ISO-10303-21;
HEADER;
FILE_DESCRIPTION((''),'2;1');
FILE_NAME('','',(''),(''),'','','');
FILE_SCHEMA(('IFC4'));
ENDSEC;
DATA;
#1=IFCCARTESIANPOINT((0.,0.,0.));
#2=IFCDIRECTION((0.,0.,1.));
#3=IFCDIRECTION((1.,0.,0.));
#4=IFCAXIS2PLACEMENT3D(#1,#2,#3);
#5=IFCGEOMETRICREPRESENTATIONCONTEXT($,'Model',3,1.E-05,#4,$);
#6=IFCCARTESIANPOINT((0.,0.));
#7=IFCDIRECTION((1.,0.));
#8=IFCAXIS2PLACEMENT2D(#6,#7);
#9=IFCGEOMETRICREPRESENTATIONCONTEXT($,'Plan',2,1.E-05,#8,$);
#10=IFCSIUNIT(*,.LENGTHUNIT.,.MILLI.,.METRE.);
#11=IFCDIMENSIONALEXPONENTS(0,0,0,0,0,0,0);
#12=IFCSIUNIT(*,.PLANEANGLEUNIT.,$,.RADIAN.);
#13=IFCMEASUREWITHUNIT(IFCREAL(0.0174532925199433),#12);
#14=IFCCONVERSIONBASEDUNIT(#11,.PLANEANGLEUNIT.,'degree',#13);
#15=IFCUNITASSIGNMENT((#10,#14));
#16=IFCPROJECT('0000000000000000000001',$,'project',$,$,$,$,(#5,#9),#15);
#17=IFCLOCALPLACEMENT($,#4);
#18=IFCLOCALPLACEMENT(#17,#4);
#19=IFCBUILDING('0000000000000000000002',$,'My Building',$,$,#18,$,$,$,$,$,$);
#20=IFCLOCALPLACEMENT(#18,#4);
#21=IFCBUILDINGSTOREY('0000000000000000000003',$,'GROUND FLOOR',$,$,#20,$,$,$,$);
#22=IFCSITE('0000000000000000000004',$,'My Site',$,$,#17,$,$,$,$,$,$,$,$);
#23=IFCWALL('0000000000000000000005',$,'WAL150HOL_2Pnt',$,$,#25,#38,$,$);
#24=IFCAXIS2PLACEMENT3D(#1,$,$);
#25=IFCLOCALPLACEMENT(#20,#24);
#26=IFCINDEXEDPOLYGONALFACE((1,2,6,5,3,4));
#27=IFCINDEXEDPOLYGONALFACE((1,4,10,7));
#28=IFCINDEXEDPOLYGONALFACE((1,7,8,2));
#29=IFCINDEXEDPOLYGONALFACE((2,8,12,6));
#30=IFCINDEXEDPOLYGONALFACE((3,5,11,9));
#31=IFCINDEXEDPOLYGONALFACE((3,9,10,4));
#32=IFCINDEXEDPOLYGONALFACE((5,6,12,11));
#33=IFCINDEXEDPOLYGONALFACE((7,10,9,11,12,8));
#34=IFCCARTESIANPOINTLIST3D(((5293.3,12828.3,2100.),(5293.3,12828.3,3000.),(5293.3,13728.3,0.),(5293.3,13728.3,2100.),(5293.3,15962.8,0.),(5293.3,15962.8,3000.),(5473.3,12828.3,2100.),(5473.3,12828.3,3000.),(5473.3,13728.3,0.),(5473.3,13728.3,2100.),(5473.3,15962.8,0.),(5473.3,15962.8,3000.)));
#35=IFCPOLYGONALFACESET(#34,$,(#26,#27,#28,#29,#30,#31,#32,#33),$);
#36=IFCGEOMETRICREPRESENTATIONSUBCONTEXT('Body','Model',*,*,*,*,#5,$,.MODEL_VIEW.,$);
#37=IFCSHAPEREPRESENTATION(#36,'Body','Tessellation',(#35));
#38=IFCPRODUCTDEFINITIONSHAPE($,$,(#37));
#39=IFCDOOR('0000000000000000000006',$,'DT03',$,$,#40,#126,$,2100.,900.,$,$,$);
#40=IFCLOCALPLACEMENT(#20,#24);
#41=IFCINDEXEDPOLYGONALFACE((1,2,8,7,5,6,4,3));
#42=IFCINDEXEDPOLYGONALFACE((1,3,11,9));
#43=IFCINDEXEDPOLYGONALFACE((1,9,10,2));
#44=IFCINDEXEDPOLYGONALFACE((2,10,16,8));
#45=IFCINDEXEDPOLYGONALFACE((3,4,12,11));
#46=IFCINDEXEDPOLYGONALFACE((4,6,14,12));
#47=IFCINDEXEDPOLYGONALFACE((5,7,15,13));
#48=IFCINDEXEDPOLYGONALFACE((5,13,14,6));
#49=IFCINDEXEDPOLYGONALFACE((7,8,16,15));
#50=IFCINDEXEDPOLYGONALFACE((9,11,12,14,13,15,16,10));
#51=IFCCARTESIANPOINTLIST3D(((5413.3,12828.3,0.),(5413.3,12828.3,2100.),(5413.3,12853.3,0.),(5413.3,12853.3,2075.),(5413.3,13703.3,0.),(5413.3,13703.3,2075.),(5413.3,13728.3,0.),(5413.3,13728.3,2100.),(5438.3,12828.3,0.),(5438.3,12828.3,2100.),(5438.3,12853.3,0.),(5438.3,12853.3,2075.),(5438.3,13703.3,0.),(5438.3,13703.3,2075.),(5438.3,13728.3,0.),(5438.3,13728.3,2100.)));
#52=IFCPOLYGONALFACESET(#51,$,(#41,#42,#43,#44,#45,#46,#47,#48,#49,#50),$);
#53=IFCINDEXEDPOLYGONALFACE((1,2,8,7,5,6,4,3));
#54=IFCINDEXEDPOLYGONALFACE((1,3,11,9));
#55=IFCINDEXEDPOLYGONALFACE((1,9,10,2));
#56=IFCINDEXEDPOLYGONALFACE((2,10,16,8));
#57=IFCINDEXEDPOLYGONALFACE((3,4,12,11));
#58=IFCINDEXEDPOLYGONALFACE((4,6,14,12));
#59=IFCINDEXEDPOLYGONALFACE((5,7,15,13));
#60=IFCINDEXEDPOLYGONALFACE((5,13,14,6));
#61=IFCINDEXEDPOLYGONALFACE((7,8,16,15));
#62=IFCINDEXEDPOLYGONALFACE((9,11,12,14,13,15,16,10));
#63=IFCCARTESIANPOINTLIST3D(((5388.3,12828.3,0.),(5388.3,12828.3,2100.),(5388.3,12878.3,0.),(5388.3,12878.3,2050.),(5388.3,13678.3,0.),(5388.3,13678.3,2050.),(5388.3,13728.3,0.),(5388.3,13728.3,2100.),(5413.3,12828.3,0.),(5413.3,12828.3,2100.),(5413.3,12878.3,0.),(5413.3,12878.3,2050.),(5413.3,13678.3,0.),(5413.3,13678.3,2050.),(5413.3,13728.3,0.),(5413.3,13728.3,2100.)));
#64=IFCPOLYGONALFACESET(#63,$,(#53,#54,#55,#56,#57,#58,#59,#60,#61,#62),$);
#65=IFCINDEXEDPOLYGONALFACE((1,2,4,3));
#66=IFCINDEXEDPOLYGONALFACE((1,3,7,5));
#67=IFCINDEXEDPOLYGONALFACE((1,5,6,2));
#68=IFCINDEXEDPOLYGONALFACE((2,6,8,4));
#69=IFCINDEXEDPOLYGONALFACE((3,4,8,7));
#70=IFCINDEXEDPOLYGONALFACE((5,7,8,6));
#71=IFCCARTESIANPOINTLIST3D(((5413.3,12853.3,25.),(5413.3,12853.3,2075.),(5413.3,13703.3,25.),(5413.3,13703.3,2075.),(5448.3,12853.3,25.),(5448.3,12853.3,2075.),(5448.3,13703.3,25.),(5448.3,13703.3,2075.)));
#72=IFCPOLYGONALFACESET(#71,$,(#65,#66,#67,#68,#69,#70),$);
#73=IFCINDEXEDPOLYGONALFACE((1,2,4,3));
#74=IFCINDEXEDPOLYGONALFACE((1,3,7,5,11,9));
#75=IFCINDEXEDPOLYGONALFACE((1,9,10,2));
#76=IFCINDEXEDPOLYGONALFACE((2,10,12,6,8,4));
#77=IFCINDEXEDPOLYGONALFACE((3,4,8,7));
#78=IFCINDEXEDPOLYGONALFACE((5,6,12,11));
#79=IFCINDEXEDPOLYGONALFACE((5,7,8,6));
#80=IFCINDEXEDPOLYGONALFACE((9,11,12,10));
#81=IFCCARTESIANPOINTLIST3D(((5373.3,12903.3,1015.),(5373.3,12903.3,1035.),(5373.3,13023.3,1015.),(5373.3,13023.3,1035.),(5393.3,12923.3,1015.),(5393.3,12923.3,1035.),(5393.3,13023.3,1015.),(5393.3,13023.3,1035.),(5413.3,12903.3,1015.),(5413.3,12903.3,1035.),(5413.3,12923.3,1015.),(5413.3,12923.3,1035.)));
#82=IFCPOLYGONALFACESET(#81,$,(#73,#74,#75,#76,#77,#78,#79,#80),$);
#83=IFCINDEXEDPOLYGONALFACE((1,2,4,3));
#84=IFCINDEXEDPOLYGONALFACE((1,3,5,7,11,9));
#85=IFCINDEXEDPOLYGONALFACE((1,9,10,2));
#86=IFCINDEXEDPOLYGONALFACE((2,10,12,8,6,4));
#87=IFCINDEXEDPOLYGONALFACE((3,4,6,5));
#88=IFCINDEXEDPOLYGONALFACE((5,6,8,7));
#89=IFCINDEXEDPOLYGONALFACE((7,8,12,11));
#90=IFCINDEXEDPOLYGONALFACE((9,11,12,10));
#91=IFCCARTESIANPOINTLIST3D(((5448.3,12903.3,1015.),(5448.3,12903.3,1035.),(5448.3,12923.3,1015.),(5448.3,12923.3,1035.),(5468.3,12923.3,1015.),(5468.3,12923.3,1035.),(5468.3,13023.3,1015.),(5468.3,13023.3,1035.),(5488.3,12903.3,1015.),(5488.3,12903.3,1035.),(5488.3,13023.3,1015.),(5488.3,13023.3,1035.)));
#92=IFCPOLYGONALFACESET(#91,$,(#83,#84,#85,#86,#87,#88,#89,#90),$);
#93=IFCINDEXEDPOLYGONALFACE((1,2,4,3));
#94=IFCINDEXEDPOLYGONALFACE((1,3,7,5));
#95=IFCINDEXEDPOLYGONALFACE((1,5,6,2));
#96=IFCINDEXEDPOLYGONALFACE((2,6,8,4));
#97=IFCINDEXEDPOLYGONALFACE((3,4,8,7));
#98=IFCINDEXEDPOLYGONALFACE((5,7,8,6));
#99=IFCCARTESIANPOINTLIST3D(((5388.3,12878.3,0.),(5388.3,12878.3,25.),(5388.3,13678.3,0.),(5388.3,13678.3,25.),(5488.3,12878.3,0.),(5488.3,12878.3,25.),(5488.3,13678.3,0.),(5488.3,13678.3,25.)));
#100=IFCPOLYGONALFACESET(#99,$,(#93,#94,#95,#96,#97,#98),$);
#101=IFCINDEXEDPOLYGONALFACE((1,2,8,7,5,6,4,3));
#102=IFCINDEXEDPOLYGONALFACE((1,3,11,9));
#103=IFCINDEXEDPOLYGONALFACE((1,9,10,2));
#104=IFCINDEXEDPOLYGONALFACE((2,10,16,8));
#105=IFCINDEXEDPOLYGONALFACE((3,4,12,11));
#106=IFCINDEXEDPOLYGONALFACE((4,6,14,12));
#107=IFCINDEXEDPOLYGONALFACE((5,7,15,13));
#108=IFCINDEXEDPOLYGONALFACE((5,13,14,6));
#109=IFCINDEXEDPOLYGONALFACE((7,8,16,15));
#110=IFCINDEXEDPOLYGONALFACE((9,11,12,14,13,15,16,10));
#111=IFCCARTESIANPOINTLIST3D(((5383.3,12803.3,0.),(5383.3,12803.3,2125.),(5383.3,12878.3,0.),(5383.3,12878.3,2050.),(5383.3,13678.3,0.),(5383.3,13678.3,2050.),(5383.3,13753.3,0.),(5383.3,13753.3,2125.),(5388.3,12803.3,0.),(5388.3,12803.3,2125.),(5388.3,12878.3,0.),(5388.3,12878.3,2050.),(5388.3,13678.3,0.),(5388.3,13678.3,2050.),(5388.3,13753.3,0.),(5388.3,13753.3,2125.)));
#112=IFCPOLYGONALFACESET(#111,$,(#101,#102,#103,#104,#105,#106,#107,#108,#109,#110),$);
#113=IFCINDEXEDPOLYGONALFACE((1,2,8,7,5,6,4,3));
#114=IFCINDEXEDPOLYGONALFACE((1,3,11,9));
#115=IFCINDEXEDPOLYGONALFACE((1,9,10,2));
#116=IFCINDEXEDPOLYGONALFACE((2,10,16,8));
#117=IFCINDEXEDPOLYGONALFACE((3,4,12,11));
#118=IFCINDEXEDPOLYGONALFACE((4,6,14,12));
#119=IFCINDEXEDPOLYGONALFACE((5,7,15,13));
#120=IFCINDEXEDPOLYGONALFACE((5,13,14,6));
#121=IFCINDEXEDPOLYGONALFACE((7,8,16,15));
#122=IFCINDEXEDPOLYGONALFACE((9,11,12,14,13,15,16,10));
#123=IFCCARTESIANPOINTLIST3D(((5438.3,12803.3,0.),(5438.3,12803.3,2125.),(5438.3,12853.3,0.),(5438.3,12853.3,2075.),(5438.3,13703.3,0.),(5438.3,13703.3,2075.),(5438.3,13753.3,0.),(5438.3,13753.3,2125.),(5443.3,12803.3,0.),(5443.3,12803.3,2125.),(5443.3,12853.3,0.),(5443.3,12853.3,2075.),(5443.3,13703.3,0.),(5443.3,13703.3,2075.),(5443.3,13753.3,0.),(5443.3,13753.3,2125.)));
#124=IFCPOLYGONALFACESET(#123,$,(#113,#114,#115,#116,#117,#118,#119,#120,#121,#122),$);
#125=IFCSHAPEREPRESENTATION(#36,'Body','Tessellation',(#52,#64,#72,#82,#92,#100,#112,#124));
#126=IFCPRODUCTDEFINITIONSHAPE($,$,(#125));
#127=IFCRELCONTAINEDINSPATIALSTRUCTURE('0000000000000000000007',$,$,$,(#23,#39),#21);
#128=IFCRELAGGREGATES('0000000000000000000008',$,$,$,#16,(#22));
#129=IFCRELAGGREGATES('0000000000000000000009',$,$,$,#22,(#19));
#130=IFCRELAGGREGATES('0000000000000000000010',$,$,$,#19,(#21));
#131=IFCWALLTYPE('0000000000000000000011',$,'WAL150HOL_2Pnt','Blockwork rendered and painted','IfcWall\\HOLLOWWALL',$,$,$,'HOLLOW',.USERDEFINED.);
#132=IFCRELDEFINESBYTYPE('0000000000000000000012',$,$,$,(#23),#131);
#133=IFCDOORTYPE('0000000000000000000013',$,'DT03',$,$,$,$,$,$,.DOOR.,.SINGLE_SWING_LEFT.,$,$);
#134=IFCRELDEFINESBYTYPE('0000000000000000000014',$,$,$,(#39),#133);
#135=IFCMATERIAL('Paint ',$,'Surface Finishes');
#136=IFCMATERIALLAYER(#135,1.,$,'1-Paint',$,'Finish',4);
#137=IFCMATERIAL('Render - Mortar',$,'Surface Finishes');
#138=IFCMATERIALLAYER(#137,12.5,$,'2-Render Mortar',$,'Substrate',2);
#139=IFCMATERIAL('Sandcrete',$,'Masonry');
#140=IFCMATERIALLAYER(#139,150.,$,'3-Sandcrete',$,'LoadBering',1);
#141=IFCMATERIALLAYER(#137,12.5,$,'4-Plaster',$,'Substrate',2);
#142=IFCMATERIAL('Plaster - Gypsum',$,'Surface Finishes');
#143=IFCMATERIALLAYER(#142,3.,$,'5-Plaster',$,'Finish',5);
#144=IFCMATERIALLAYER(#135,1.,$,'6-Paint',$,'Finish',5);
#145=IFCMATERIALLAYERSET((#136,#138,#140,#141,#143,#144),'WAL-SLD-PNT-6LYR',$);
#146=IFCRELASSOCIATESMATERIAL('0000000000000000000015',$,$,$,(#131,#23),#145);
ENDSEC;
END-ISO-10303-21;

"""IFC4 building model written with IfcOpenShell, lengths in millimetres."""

from ifc_helpers import new_model, entity, si_unit, converted_unit, frame, origin_with_axes, origin_2d_with_axis, place, context, subcontext, project, spatial, line, indexed_curve, outline, extrude, shape, source, transform, mapped, material, layer, layer_set, layer_usage, type_object, type_shapes, element, fill, save


model = new_model("IFC4")

# Units and contexts
model_context = context("Model", 3, precision=1e-05, world=origin_with_axes())
plan_context = context("Plan", 2, precision=1e-05, world=origin_2d_with_axis())
body_context_1 = subcontext(model_context, "Body", "Model", "MODEL_VIEW")
body_context_2 = subcontext(plan_context, "Body", "Plan", "PLAN_VIEW")
ifc_project = project(units=[si_unit("LENGTHUNIT", "METRE", prefix="MILLI"), converted_unit("PLANEANGLEUNIT", "degree", entity("IfcReal", 0.0174532925199433), si_unit("PLANEANGLEUNIT", "RADIAN"), dimensions=[0, 0, 0, 0, 0, 0, 0])], contexts=[model_context, plan_context])

# Site, building, storey
site_placement = place(None, origin_with_axes())
site = spatial("IfcSite", under=ifc_project, at=site_placement, Name="My Site")
building_placement = place(site_placement, origin_with_axes())
building = spatial("IfcBuilding", under=site, at=building_placement, Name="My Building")
storey_placement = place(building_placement, origin_with_axes())
storey = spatial("IfcBuildingStorey", under=building, at=storey_placement, Name="GROUND FLOOR")

# Shared definitions
ifc_material_1 = material(Name="Paint ", Category="Surface Finishes")
ifc_layer_1 = layer(ifc_material_1, 1.0, Name="1-Paint", Category="Finish", Priority=4)
ifc_material_2 = material(Name="Render - Mortar", Category="Surface Finishes")
ifc_layer_2 = layer(ifc_material_2, 12.5, Name="2-Render Mortar", Category="Substrate", Priority=2)
ifc_material_3 = material(Name="Sandcrete", Category="Masonry")
ifc_layer_3 = layer(ifc_material_3, 150.0, Name="3-Sandcrete", Category="LoadBering", Priority=1)
ifc_layer_4 = layer(ifc_material_2, 12.5, Name="4-Plaster", Category="Substrate", Priority=2)
ifc_material_4 = material(Name="Plaster - Gypsum", Category="Surface Finishes")
ifc_layer_5 = layer(ifc_material_4, 3.0, Name="5-Plaster", Category="Finish", Priority=5)
ifc_layer_6 = layer(ifc_material_1, 1.0, Name="6-Paint", Category="Finish", Priority=5)
ifc_layer_set_1 = layer_set([ifc_layer_1, ifc_layer_2, ifc_layer_3, ifc_layer_4, ifc_layer_5, ifc_layer_6], Name="WAL-SLD-PNT-6LYR")
wall_type_1 = type_object("IfcWallType", Name="WAL150HOL_2Pnt", Description="Blockwork rendered and painted", ApplicableOccurrence="IfcWall\\HOLLOWWALL", ElementType="HOLLOW", PredefinedType="USERDEFINED", material=ifc_layer_set_1)

# Shared definitions
shared_shape_1 = source(origin_with_axes(), body_context_1, "Body", "SweptSolid", [
    extrude(outline(indexed_curve([(0.0, 0.0), (900.0, 0.0), (900.0, 2100.0), (0.0, 2100.0)], segments=[line(1, 2, 3, 4, 1)])), frame((0.0, -100.0, 0.0), z_axis=(0.0, -1.0, 0.0), x_axis=(1.0, 0.0, 0.0)), (0.0, 0.0, -1.0), 380.0),
])
door_type_1 = type_object("IfcDoorType", Name="DT03", OperationType="SINGLE_SWING_LEFT", PredefinedType="DOOR")
shared_shape_2 = source(origin_with_axes(), body_context_1, "Body", "SweptSolid", [
    extrude(outline(indexed_curve([(0.0, 0.0), (0.0, 2100.0), (900.0, 2100.0), (900.0, 0.0), (875.0, 0.0), (875.0, 2075.0), (25.0, 2075.0), (25.0, 0.0)], segments=[line(1, 2, 3, 4, 5, 6, 7, 8, 1)])), frame((0.0, 25.0, 0.0), z_axis=(0.0, -1.0, 0.0), x_axis=(1.0, 0.0, 0.0)), (0.0, 0.0, -1.0), 25.0),
    extrude(outline(indexed_curve([(0.0, 0.0), (0.0, 2100.0), (900.0, 2100.0), (900.0, 0.0), (850.0, 0.0), (850.0, 2050.0), (50.0, 2050.0), (50.0, 0.0)], segments=[line(1, 2, 3, 4, 5, 6, 7, 8, 1)])), frame((0.0, 0.0, 0.0), z_axis=(0.0, -1.0, 0.0), x_axis=(1.0, 0.0, 0.0)), (0.0, 0.0, -1.0), 25.0),
    extrude(outline(indexed_curve([(0.0, 0.0), (850.0, 0.0), (850.0, 35.0), (0.0, 35.0)], segments=[line(1, 2, 3, 4, 1)])), frame((25.0, 25.0, 25.0), z_axis=(0.0, 0.0, 1.0), x_axis=(1.0, 0.0, 0.0)), (0.0, 0.0, 1.0), 2050.0),
    extrude(outline(indexed_curve([(0.0, 0.0), (0.0, -40.0), (-120.0, -40.0), (-120.0, -20.0), (-20.0, -20.0), (-20.0, 0.0)], segments=[line(1, 2, 3, 4, 5, 6, 1)])), frame((825.0, 25.0, 1015.0), z_axis=(0.0, 0.0, 1.0), x_axis=(1.0, 0.0, 0.0)), (0.0, 0.0, 1.0), 20.0),
    extrude(outline(indexed_curve([(0.0, 0.0), (0.0, 40.0), (-120.0, 40.0), (-120.0, 20.0), (-20.0, 20.0), (-20.0, 0.0)], segments=[line(1, 2, 3, 4, 5, 6, 1)])), frame((825.0, 60.0, 1015.0), z_axis=(0.0, 0.0, 1.0), x_axis=(1.0, 0.0, 0.0)), (0.0, 0.0, 1.0), 20.0),
    extrude(outline(indexed_curve([(0.0, 0.0), (800.0, 0.0), (800.0, 100.0), (0.0, 100.0)], segments=[line(1, 2, 3, 4, 1)])), frame((50.0, 0.0, 0.0), z_axis=(0.0, 0.0, 1.0), x_axis=(1.0, 0.0, 0.0)), (0.0, 0.0, 1.0), 25.0),
    extrude(outline(indexed_curve([(0.0, 0.0), (0.0, 2125.0), (950.0, 2125.0), (950.0, 0.0), (875.0, 0.0), (875.0, 2050.0), (75.0, 2050.0), (75.0, 0.0)], segments=[line(1, 2, 3, 4, 5, 6, 7, 8, 1)])), frame((-25.0, -5.0, 0.0), z_axis=(0.0, -1.0, 0.0), x_axis=(1.0, 0.0, 0.0)), (0.0, 0.0, -1.0), 5.0),
    extrude(outline(indexed_curve([(0.0, 0.0), (0.0, 2125.0), (950.0, 2125.0), (950.0, 0.0), (900.0, 0.0), (900.0, 2075.0), (50.0, 2075.0), (50.0, 0.0)], segments=[line(1, 2, 3, 4, 5, 6, 7, 8, 1)])), frame((-25.0, 50.0, 0.0), z_axis=(0.0, -1.0, 0.0), x_axis=(1.0, 0.0, 0.0)), (0.0, 0.0, -1.0), 5.0),
])
shared_shape_3 = source(origin_with_axes(), body_context_2, "Body", "Curve2D", [
    entity("IfcIndexedPolyCurve", entity("IfcCartesianPointList2D", [[0.0, 0.0], [0.0, 50.0], [25.0, 50.0], [25.0, 25.0], [50.0, 25.0], [50.0, 0.0]]), [entity("IfcLineIndex", [1, 2, 3, 4, 5, 6, 1])]),
    entity("IfcIndexedPolyCurve", entity("IfcCartesianPointList2D", [[900.0, 0.0], [900.0, 50.0], [875.0, 50.0], [875.0, 25.0], [850.0, 25.0], [850.0, 0.0]]), [entity("IfcLineIndex", [1, 2, 3, 4, 5, 6, 1])]),
    entity("IfcTrimmedCurve", entity("IfcEllipse", entity("IfcAxis2Placement2D", entity("IfcCartesianPoint", [60.0, 50.0]), entity("IfcDirection", [1.0, 0.0])), 815.0, 850.0), [entity("IfcCartesianPoint", [875.0, 50.0])], [entity("IfcCartesianPoint", [60.0, 900.0])], True, "CARTESIAN"),
    entity("IfcIndexedPolyCurve", entity("IfcCartesianPointList2D", [[25.0, 50.0], [60.0, 50.0], [60.0, 900.0], [25.0, 900.0]]), [entity("IfcLineIndex", [1, 2, 3, 4, 1])]),
])
type_shapes(door_type_1, [shared_shape_2, shared_shape_3])

# Wall, opening, door
ifc_layer_usage_1 = layer_usage(ifc_layer_set_1, "AXIS2", "POSITIVE", 0.0)
wall_1_placement = place(storey_placement, frame((5473.3, 12828.3, 0.0), z_axis=(0.0, 0.0, 1.0), x_axis=(0.000001, 1.0, 0.0)))
wall_1 = element("IfcWall", 1, at=wall_1_placement, inside=storey, type_object=wall_type_1, material=ifc_layer_usage_1, Name="WAL150HOL_2Pnt", context=body_context_1, shape_type="SweptSolid", body=[
    extrude(outline(indexed_curve([(0.0, 0.0), (0.0, 180.0), (3134.5, 180.0), (3134.5, 0.0), (0.0, 0.0)], self_intersect=False)), origin_with_axes(), (0.0, 0.0, 1.0), 3000.0),
])
opening_1_placement = place(wall_1_placement, frame((0.0, 0.0, 0.0), z_axis=(0.0, 0.0, 1.0), x_axis=(1.0, 0.0, 0.0)))
opening_1 = element("IfcOpeningElement", 2, at=opening_1_placement, cuts=wall_1, PredefinedType="OPENING", context=body_context_1, shape_type="MappedRepresentation", body=[
    mapped(shared_shape_1, transform((0.0, 0.0, 0.0), x_axis=(1.0, 0.0, 0.0), y_axis=(0.0, 1.0, 0.0), z_axis=(0.0, 0.0, 1.0), scale=1.0)),
])
door_1_placement = place(opening_1_placement, frame((900.0, 85.0, 0.0), z_axis=(0.0, 0.0, 1.0), x_axis=(-1.0, 0.0, 0.0)))
door_1 = element("IfcDoor", 3, at=door_1_placement, inside=storey, type_object=door_type_1, Name="DT03", OverallHeight=2100.0, OverallWidth=900.0, shapes=[
    shape(body_context_1, "Body", "MappedRepresentation", [mapped(shared_shape_2, transform((0.0, 0.0, 0.0), x_axis=(1.0, 0.0, 0.0), y_axis=(0.0, 1.0, 0.0), z_axis=(0.0, 0.0, 1.0), scale=1.0))]),
    shape(body_context_2, "Body", "MappedRepresentation", [mapped(shared_shape_3, transform((0.0, 0.0, 0.0), x_axis=(1.0, 0.0, 0.0), y_axis=(0.0, 1.0, 0.0), z_axis=(0.0, 0.0, 1.0), scale=1.0))]),
])
fill(opening_1, door_1)

save(model, "model.ifc")
